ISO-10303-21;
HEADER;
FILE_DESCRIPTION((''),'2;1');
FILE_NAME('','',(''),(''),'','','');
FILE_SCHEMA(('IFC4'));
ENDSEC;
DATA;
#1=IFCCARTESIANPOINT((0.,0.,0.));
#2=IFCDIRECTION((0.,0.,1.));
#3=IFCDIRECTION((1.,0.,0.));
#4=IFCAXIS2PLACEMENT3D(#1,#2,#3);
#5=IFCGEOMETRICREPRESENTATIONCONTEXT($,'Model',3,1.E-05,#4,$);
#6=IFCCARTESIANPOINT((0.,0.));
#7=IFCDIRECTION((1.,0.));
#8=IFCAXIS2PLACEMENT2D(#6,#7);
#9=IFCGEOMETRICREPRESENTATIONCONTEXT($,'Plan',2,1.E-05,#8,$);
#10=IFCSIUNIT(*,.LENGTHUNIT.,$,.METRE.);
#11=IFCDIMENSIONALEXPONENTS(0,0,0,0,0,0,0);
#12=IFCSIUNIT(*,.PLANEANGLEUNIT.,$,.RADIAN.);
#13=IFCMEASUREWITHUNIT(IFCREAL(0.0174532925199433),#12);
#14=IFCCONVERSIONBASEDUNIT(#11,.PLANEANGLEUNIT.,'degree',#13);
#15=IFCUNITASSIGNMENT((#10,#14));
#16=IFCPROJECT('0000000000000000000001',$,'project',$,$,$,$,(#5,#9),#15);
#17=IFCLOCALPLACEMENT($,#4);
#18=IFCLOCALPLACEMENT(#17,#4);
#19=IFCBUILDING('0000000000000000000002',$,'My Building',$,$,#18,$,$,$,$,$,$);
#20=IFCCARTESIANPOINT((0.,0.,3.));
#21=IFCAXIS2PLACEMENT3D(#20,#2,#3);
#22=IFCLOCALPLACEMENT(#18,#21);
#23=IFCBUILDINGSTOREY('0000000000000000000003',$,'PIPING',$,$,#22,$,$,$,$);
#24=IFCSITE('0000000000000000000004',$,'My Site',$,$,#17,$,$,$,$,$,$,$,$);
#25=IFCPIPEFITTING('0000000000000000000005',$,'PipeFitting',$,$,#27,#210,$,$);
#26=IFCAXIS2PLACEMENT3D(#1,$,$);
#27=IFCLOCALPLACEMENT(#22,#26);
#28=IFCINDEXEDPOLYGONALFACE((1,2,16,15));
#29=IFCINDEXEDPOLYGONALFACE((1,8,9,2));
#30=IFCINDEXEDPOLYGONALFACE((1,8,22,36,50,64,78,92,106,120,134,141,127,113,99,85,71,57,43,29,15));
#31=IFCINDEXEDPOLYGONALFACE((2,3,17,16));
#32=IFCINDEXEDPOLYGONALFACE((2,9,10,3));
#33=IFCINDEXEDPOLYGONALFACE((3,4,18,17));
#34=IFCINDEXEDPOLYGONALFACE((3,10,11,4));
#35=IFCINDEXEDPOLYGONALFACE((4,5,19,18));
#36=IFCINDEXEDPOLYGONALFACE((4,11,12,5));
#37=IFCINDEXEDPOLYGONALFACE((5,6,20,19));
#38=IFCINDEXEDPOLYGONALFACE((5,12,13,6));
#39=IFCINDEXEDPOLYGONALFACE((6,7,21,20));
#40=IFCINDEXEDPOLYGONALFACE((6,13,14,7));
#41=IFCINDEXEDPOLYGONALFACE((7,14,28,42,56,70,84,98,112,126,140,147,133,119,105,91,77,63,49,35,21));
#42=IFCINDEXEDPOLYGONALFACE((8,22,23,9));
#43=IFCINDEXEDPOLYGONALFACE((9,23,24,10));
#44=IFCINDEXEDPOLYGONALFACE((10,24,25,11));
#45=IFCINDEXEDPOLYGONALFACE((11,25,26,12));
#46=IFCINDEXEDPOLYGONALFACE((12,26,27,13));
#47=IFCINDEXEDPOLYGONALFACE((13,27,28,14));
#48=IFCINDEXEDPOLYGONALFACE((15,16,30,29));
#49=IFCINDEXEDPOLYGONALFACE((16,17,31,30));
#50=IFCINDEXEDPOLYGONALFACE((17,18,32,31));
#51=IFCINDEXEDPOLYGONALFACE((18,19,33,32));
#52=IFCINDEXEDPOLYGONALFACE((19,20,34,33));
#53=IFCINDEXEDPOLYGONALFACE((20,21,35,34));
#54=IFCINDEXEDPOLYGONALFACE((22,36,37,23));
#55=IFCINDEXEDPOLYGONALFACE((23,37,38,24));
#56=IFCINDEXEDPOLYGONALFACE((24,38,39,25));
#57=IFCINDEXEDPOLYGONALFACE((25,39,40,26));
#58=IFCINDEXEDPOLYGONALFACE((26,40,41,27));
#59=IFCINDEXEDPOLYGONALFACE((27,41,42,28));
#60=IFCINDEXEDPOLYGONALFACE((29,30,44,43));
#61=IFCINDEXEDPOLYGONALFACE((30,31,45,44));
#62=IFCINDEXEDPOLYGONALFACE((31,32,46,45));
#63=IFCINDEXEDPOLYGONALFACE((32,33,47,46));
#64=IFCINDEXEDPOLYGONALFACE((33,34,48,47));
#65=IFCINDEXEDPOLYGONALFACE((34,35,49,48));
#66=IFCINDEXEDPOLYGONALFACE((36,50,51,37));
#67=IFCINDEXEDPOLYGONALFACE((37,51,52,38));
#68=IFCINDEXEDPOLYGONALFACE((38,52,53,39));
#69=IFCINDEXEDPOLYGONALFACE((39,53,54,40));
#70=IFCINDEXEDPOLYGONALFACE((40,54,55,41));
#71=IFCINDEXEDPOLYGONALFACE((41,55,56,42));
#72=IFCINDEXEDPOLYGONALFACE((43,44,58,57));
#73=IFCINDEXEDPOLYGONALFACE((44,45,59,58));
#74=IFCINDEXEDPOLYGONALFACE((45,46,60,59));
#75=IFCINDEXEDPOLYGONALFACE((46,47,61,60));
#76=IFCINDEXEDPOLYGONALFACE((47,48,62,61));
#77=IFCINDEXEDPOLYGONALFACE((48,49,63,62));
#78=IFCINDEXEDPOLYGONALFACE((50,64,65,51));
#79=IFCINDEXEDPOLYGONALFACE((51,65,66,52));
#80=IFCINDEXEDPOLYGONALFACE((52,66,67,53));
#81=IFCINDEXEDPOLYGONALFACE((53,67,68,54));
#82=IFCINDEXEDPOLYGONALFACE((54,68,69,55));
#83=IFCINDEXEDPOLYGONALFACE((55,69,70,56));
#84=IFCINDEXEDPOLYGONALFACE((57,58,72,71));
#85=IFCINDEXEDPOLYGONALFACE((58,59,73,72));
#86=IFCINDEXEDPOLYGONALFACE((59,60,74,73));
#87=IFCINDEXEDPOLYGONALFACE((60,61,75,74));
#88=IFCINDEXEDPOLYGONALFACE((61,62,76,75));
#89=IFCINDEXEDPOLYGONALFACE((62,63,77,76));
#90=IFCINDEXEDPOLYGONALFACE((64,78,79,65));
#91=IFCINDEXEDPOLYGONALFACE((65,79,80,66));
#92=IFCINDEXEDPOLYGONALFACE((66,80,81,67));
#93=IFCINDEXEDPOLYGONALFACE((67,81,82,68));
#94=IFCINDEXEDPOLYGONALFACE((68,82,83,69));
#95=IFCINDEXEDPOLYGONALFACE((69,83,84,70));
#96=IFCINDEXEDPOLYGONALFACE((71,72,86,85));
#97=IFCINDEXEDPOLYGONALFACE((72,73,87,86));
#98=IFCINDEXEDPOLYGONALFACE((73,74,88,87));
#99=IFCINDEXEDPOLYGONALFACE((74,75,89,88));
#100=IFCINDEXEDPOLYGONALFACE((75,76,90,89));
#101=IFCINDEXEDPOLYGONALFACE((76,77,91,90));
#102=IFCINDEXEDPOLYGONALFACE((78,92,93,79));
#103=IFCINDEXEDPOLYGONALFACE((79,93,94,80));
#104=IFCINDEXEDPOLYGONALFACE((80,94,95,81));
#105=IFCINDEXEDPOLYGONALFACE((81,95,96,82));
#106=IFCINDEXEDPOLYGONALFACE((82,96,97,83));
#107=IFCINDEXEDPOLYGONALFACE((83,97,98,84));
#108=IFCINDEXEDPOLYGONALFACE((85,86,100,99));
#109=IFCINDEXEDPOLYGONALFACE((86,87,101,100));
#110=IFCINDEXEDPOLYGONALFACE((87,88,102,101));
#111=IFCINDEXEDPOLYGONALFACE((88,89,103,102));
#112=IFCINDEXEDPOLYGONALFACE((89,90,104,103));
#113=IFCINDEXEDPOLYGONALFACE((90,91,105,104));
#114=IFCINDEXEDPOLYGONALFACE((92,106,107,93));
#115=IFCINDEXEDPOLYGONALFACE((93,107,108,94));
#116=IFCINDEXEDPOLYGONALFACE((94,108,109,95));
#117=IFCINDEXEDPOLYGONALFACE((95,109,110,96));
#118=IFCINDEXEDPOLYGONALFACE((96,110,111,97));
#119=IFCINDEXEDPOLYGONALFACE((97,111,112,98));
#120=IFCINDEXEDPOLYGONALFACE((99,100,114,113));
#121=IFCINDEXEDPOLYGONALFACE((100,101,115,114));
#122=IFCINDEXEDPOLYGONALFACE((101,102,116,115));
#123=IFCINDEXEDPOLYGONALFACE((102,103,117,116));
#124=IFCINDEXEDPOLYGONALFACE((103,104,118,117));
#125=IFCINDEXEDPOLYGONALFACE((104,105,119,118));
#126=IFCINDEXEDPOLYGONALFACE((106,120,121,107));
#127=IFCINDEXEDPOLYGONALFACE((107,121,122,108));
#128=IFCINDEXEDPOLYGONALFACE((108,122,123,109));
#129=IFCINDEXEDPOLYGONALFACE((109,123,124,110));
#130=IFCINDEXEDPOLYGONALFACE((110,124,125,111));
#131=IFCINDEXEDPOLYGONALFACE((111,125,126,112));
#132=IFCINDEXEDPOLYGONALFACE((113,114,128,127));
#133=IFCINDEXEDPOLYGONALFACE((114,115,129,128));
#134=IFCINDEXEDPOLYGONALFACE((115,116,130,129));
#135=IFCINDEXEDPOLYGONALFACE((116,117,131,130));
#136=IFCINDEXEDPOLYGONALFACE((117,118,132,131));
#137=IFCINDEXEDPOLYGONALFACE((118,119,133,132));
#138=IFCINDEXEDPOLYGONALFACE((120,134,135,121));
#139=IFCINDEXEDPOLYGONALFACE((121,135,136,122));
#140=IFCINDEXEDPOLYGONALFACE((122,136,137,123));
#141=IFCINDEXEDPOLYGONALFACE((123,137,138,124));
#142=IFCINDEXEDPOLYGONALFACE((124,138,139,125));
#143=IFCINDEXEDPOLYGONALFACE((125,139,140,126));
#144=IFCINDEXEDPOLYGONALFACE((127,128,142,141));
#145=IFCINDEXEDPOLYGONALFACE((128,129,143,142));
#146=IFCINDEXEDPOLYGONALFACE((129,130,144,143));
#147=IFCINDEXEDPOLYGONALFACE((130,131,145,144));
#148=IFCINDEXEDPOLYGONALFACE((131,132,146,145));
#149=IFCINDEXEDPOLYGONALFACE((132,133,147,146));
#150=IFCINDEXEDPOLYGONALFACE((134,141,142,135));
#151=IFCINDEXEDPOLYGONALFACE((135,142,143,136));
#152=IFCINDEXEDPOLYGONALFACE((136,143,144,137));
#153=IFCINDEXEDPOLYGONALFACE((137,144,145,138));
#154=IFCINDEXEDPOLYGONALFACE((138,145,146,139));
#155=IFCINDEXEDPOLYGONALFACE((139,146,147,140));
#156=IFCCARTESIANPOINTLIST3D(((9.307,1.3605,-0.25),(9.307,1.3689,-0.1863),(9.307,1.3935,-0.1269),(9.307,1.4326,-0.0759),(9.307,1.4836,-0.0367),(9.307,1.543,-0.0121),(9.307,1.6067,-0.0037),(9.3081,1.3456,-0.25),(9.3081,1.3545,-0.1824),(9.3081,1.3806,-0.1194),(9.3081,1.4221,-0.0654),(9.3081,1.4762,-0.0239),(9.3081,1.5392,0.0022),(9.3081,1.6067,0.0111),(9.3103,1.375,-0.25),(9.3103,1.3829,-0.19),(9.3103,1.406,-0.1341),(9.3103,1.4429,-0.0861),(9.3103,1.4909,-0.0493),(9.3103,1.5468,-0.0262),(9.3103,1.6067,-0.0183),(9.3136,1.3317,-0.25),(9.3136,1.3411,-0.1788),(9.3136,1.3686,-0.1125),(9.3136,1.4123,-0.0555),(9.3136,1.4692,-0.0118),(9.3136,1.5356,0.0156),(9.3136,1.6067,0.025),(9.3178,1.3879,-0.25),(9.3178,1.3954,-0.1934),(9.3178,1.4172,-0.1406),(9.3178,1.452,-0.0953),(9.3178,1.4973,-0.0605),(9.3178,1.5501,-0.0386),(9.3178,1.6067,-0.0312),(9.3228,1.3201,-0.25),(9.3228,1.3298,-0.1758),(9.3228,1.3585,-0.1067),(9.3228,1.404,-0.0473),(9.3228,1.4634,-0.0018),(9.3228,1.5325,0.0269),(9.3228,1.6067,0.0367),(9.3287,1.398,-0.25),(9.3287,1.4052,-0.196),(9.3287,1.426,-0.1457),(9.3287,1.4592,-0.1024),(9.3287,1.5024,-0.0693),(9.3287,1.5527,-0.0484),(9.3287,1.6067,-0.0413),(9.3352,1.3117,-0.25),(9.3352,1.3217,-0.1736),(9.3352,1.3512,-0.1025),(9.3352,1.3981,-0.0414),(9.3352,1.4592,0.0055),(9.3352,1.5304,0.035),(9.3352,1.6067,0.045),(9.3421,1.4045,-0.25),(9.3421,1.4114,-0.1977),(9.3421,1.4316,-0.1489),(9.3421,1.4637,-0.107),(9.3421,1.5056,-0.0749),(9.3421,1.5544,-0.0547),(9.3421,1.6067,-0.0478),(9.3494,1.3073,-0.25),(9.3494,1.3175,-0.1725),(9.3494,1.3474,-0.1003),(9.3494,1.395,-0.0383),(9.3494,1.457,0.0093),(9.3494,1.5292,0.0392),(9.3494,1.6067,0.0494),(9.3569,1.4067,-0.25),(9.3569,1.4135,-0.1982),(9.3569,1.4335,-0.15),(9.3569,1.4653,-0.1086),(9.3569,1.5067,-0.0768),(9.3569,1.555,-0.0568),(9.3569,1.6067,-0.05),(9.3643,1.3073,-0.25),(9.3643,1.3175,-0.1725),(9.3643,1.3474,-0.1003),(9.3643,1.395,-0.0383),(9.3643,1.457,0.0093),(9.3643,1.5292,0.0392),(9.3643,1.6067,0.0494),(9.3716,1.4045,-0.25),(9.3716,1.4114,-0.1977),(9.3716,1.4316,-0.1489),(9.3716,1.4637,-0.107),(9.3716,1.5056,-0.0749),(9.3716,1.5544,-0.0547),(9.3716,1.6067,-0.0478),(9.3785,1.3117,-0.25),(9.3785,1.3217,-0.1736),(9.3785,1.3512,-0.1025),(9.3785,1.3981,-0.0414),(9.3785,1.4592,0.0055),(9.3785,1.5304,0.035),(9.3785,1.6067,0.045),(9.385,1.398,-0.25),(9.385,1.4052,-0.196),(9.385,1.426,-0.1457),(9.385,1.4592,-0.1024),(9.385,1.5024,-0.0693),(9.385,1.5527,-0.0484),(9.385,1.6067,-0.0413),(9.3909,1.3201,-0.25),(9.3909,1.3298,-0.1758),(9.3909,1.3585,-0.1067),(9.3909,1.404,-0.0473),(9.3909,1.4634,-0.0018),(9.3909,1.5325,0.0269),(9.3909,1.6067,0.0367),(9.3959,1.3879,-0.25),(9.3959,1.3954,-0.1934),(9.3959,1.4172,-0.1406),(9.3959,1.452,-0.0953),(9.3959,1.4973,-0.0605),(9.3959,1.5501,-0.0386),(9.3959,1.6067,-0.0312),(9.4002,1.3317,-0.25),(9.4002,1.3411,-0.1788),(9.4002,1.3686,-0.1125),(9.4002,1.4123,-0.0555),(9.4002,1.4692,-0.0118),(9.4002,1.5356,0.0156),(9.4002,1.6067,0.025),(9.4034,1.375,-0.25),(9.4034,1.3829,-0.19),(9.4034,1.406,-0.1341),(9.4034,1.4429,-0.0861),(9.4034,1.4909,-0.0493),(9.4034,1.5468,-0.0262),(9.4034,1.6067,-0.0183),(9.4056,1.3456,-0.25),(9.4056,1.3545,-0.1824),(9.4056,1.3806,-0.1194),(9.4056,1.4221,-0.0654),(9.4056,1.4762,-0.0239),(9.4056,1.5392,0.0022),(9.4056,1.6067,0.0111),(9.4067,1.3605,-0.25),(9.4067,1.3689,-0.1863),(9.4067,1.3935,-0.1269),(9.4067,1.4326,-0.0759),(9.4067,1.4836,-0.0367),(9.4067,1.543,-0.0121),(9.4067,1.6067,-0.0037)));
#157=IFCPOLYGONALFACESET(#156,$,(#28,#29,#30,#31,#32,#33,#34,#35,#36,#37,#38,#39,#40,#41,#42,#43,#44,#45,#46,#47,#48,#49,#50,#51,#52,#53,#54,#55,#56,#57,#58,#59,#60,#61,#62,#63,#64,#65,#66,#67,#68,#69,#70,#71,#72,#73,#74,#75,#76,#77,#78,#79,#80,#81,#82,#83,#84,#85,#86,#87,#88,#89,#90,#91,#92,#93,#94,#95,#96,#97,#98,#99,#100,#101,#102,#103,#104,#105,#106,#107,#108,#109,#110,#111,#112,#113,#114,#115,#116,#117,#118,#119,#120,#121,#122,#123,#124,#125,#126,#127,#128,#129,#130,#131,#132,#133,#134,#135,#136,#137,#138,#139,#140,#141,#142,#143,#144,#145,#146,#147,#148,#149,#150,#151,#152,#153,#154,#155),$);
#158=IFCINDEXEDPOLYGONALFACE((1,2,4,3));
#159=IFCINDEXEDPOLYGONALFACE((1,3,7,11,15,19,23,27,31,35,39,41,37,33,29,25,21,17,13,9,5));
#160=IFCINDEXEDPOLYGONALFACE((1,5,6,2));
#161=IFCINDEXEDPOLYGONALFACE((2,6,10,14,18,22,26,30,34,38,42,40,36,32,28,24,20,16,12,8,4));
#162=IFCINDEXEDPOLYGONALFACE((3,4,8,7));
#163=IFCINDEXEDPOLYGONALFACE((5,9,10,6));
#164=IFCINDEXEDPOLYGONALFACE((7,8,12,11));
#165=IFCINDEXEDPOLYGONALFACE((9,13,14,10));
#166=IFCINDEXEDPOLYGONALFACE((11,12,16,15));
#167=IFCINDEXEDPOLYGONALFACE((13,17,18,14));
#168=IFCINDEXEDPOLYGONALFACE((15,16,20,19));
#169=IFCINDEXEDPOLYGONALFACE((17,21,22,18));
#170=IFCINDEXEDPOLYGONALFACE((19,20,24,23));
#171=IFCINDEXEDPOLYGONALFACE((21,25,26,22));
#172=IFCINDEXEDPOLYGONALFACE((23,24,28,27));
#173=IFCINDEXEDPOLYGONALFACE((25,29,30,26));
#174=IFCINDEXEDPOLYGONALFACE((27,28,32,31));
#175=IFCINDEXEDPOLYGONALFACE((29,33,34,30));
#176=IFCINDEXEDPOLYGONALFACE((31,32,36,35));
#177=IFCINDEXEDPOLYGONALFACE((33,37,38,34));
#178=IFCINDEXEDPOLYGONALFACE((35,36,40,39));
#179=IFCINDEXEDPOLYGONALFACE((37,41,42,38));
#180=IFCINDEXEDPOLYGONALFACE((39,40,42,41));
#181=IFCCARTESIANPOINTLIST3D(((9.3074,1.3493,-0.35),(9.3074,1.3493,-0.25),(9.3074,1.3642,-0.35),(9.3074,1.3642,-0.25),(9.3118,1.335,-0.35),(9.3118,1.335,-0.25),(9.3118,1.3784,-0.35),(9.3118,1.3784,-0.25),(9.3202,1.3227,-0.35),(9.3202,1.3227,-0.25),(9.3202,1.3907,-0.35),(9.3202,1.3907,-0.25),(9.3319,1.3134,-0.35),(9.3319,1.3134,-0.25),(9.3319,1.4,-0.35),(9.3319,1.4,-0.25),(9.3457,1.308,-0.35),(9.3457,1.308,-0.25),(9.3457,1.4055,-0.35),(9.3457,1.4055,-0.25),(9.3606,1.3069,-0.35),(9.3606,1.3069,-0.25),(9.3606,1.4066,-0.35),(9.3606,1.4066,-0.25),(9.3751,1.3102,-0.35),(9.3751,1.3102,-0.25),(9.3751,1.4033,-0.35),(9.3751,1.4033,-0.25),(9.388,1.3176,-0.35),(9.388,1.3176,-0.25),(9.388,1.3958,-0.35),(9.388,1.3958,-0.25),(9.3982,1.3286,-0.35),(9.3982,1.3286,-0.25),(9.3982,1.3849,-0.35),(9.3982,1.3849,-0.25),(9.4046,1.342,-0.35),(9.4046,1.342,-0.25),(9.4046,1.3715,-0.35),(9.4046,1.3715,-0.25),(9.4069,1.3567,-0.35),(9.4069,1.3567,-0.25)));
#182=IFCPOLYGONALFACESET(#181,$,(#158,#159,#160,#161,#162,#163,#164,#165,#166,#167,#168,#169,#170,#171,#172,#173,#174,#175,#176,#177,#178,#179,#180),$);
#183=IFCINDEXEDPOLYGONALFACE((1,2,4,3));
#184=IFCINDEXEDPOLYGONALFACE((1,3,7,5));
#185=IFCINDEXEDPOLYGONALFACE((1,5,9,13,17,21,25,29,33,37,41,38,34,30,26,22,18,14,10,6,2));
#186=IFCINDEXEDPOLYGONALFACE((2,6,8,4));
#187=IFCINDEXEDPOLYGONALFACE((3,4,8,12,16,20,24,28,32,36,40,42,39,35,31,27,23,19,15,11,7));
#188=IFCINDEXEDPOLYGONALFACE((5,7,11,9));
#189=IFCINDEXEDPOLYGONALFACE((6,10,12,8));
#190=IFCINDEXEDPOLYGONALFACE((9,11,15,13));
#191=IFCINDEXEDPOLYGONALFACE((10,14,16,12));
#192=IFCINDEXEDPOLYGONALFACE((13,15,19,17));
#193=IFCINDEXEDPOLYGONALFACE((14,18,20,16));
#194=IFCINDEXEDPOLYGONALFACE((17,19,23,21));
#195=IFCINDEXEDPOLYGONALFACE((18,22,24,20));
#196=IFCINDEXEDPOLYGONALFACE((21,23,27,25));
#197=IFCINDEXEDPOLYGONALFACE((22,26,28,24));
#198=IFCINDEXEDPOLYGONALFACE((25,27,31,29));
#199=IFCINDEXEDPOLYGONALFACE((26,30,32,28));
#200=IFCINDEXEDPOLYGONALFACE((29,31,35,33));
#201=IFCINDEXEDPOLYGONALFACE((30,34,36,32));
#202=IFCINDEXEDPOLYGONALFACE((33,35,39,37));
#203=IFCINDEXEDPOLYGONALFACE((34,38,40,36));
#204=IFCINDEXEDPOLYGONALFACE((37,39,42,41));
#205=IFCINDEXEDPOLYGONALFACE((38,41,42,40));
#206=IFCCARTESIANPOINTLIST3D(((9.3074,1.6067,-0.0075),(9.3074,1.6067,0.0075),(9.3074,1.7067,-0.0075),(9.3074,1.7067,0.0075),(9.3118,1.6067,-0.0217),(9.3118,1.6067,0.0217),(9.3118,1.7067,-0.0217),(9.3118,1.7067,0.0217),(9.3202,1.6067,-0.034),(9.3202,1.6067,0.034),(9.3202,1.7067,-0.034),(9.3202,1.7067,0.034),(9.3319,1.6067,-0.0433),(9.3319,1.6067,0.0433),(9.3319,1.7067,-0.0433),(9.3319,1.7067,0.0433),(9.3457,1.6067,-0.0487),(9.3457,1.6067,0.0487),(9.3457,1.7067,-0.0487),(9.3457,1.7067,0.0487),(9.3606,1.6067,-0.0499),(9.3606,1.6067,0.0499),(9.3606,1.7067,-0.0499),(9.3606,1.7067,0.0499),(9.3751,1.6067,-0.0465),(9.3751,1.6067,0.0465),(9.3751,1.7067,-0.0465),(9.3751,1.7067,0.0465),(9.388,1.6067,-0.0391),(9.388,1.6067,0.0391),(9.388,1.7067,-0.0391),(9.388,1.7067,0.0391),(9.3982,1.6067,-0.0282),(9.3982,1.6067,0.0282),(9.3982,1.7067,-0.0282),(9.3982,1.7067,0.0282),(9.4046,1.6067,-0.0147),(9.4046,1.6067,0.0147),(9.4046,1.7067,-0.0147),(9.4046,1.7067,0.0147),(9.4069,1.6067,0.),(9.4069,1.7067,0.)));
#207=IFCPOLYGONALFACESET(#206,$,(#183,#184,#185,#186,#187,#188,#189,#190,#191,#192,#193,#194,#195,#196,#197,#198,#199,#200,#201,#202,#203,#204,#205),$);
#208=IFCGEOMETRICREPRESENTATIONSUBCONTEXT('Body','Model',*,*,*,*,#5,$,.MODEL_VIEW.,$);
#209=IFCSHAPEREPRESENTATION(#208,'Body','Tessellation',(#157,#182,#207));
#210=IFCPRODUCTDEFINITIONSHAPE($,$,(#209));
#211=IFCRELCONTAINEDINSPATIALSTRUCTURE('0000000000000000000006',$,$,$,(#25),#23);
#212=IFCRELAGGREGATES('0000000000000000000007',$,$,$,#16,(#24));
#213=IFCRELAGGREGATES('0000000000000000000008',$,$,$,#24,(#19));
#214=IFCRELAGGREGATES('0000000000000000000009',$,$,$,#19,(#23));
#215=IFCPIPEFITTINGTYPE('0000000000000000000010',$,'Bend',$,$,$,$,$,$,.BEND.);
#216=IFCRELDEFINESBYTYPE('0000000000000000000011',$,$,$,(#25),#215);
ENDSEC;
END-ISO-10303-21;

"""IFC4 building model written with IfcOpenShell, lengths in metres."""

from ifc_helpers import new_model, entity, si_unit, converted_unit, frame, origin_with_axes, origin_2d_with_axis, place, context, subcontext, project, spatial, circle, extrude, source, transform, mapped, type_object, type_shapes, element, save


model = new_model("IFC4")

# Units and contexts
model_context = context("Model", 3, precision=1e-05, world=origin_with_axes())
plan_context = context("Plan", 2, precision=1e-05, world=origin_2d_with_axis())
body_context = subcontext(model_context, "Body", "Model", "MODEL_VIEW")
ifc_project = project(units=[si_unit("LENGTHUNIT", "METRE"), converted_unit("PLANEANGLEUNIT", "degree", entity("IfcReal", 0.0174532925199433), si_unit("PLANEANGLEUNIT", "RADIAN"), dimensions=[0, 0, 0, 0, 0, 0, 0])], contexts=[model_context, plan_context])

# Site, building, storey
site_placement = place(None, origin_with_axes())
site = spatial("IfcSite", under=ifc_project, at=site_placement, Name="My Site")
building_placement = place(site_placement, origin_with_axes())
building = spatial("IfcBuilding", under=site, at=building_placement, Name="My Building")
storey_placement = place(building_placement, frame((0.0, 0.0, 3.0), z_axis=(0.0, 0.0, 1.0), x_axis=(1.0, 0.0, 0.0)))
storey = spatial("IfcBuildingStorey", under=building, at=storey_placement, Name="PIPING")

# Pipe fitting
pipe_fitting_type_1 = type_object("IfcPipeFittingType", Name="Bend", PredefinedType="BEND")
shared_shape = source(origin_with_axes(), body_context, "Body", "SolidModel", [
    entity("IfcSweptDiskSolid", entity("IfcIndexedPolyCurve", entity("IfcCartesianPointList3D", [[0.0, 0.0, -0.1], [0.0, -0.0732, -0.2768], [0.0, -0.25, -0.35]]), [entity("IfcArcIndex", [1, 2, 3])]), 0.05),
    extrude(circle(Radius=0.05), origin_with_axes(), (0.0, 0.0, -1.0), 0.1),
    extrude(circle(Radius=0.05), frame((0.0, -0.25, -0.35), z_axis=(0.0, -1.0, 0.0), x_axis=(1.0, 0.0, 0.0)), (0.0, 0.0, 1.0), 0.1),
])
type_shapes(pipe_fitting_type_1, [shared_shape])
for number, where, z_axis, x_axis, name in (
    (1, (9.3569, 1.3567, -0.35), (0.0, 0.0, -1.0), (1.0, 0.0, 0.0), "PipeFitting"),
):
    element("IfcPipeFitting", number, at=place(storey_placement, frame(where, z_axis=z_axis, x_axis=x_axis)), inside=storey, type_object=pipe_fitting_type_1, Name=name, context=body_context, shape_type="MappedRepresentation", body=[
        mapped(shared_shape, transform((0.0, 0.0, 0.0), x_axis=(1.0, 0.0, 0.0), y_axis=(0.0, 1.0, 0.0), z_axis=(0.0, 0.0, 1.0), scale=1.0)),
    ])

save(model, "model.ifc")
